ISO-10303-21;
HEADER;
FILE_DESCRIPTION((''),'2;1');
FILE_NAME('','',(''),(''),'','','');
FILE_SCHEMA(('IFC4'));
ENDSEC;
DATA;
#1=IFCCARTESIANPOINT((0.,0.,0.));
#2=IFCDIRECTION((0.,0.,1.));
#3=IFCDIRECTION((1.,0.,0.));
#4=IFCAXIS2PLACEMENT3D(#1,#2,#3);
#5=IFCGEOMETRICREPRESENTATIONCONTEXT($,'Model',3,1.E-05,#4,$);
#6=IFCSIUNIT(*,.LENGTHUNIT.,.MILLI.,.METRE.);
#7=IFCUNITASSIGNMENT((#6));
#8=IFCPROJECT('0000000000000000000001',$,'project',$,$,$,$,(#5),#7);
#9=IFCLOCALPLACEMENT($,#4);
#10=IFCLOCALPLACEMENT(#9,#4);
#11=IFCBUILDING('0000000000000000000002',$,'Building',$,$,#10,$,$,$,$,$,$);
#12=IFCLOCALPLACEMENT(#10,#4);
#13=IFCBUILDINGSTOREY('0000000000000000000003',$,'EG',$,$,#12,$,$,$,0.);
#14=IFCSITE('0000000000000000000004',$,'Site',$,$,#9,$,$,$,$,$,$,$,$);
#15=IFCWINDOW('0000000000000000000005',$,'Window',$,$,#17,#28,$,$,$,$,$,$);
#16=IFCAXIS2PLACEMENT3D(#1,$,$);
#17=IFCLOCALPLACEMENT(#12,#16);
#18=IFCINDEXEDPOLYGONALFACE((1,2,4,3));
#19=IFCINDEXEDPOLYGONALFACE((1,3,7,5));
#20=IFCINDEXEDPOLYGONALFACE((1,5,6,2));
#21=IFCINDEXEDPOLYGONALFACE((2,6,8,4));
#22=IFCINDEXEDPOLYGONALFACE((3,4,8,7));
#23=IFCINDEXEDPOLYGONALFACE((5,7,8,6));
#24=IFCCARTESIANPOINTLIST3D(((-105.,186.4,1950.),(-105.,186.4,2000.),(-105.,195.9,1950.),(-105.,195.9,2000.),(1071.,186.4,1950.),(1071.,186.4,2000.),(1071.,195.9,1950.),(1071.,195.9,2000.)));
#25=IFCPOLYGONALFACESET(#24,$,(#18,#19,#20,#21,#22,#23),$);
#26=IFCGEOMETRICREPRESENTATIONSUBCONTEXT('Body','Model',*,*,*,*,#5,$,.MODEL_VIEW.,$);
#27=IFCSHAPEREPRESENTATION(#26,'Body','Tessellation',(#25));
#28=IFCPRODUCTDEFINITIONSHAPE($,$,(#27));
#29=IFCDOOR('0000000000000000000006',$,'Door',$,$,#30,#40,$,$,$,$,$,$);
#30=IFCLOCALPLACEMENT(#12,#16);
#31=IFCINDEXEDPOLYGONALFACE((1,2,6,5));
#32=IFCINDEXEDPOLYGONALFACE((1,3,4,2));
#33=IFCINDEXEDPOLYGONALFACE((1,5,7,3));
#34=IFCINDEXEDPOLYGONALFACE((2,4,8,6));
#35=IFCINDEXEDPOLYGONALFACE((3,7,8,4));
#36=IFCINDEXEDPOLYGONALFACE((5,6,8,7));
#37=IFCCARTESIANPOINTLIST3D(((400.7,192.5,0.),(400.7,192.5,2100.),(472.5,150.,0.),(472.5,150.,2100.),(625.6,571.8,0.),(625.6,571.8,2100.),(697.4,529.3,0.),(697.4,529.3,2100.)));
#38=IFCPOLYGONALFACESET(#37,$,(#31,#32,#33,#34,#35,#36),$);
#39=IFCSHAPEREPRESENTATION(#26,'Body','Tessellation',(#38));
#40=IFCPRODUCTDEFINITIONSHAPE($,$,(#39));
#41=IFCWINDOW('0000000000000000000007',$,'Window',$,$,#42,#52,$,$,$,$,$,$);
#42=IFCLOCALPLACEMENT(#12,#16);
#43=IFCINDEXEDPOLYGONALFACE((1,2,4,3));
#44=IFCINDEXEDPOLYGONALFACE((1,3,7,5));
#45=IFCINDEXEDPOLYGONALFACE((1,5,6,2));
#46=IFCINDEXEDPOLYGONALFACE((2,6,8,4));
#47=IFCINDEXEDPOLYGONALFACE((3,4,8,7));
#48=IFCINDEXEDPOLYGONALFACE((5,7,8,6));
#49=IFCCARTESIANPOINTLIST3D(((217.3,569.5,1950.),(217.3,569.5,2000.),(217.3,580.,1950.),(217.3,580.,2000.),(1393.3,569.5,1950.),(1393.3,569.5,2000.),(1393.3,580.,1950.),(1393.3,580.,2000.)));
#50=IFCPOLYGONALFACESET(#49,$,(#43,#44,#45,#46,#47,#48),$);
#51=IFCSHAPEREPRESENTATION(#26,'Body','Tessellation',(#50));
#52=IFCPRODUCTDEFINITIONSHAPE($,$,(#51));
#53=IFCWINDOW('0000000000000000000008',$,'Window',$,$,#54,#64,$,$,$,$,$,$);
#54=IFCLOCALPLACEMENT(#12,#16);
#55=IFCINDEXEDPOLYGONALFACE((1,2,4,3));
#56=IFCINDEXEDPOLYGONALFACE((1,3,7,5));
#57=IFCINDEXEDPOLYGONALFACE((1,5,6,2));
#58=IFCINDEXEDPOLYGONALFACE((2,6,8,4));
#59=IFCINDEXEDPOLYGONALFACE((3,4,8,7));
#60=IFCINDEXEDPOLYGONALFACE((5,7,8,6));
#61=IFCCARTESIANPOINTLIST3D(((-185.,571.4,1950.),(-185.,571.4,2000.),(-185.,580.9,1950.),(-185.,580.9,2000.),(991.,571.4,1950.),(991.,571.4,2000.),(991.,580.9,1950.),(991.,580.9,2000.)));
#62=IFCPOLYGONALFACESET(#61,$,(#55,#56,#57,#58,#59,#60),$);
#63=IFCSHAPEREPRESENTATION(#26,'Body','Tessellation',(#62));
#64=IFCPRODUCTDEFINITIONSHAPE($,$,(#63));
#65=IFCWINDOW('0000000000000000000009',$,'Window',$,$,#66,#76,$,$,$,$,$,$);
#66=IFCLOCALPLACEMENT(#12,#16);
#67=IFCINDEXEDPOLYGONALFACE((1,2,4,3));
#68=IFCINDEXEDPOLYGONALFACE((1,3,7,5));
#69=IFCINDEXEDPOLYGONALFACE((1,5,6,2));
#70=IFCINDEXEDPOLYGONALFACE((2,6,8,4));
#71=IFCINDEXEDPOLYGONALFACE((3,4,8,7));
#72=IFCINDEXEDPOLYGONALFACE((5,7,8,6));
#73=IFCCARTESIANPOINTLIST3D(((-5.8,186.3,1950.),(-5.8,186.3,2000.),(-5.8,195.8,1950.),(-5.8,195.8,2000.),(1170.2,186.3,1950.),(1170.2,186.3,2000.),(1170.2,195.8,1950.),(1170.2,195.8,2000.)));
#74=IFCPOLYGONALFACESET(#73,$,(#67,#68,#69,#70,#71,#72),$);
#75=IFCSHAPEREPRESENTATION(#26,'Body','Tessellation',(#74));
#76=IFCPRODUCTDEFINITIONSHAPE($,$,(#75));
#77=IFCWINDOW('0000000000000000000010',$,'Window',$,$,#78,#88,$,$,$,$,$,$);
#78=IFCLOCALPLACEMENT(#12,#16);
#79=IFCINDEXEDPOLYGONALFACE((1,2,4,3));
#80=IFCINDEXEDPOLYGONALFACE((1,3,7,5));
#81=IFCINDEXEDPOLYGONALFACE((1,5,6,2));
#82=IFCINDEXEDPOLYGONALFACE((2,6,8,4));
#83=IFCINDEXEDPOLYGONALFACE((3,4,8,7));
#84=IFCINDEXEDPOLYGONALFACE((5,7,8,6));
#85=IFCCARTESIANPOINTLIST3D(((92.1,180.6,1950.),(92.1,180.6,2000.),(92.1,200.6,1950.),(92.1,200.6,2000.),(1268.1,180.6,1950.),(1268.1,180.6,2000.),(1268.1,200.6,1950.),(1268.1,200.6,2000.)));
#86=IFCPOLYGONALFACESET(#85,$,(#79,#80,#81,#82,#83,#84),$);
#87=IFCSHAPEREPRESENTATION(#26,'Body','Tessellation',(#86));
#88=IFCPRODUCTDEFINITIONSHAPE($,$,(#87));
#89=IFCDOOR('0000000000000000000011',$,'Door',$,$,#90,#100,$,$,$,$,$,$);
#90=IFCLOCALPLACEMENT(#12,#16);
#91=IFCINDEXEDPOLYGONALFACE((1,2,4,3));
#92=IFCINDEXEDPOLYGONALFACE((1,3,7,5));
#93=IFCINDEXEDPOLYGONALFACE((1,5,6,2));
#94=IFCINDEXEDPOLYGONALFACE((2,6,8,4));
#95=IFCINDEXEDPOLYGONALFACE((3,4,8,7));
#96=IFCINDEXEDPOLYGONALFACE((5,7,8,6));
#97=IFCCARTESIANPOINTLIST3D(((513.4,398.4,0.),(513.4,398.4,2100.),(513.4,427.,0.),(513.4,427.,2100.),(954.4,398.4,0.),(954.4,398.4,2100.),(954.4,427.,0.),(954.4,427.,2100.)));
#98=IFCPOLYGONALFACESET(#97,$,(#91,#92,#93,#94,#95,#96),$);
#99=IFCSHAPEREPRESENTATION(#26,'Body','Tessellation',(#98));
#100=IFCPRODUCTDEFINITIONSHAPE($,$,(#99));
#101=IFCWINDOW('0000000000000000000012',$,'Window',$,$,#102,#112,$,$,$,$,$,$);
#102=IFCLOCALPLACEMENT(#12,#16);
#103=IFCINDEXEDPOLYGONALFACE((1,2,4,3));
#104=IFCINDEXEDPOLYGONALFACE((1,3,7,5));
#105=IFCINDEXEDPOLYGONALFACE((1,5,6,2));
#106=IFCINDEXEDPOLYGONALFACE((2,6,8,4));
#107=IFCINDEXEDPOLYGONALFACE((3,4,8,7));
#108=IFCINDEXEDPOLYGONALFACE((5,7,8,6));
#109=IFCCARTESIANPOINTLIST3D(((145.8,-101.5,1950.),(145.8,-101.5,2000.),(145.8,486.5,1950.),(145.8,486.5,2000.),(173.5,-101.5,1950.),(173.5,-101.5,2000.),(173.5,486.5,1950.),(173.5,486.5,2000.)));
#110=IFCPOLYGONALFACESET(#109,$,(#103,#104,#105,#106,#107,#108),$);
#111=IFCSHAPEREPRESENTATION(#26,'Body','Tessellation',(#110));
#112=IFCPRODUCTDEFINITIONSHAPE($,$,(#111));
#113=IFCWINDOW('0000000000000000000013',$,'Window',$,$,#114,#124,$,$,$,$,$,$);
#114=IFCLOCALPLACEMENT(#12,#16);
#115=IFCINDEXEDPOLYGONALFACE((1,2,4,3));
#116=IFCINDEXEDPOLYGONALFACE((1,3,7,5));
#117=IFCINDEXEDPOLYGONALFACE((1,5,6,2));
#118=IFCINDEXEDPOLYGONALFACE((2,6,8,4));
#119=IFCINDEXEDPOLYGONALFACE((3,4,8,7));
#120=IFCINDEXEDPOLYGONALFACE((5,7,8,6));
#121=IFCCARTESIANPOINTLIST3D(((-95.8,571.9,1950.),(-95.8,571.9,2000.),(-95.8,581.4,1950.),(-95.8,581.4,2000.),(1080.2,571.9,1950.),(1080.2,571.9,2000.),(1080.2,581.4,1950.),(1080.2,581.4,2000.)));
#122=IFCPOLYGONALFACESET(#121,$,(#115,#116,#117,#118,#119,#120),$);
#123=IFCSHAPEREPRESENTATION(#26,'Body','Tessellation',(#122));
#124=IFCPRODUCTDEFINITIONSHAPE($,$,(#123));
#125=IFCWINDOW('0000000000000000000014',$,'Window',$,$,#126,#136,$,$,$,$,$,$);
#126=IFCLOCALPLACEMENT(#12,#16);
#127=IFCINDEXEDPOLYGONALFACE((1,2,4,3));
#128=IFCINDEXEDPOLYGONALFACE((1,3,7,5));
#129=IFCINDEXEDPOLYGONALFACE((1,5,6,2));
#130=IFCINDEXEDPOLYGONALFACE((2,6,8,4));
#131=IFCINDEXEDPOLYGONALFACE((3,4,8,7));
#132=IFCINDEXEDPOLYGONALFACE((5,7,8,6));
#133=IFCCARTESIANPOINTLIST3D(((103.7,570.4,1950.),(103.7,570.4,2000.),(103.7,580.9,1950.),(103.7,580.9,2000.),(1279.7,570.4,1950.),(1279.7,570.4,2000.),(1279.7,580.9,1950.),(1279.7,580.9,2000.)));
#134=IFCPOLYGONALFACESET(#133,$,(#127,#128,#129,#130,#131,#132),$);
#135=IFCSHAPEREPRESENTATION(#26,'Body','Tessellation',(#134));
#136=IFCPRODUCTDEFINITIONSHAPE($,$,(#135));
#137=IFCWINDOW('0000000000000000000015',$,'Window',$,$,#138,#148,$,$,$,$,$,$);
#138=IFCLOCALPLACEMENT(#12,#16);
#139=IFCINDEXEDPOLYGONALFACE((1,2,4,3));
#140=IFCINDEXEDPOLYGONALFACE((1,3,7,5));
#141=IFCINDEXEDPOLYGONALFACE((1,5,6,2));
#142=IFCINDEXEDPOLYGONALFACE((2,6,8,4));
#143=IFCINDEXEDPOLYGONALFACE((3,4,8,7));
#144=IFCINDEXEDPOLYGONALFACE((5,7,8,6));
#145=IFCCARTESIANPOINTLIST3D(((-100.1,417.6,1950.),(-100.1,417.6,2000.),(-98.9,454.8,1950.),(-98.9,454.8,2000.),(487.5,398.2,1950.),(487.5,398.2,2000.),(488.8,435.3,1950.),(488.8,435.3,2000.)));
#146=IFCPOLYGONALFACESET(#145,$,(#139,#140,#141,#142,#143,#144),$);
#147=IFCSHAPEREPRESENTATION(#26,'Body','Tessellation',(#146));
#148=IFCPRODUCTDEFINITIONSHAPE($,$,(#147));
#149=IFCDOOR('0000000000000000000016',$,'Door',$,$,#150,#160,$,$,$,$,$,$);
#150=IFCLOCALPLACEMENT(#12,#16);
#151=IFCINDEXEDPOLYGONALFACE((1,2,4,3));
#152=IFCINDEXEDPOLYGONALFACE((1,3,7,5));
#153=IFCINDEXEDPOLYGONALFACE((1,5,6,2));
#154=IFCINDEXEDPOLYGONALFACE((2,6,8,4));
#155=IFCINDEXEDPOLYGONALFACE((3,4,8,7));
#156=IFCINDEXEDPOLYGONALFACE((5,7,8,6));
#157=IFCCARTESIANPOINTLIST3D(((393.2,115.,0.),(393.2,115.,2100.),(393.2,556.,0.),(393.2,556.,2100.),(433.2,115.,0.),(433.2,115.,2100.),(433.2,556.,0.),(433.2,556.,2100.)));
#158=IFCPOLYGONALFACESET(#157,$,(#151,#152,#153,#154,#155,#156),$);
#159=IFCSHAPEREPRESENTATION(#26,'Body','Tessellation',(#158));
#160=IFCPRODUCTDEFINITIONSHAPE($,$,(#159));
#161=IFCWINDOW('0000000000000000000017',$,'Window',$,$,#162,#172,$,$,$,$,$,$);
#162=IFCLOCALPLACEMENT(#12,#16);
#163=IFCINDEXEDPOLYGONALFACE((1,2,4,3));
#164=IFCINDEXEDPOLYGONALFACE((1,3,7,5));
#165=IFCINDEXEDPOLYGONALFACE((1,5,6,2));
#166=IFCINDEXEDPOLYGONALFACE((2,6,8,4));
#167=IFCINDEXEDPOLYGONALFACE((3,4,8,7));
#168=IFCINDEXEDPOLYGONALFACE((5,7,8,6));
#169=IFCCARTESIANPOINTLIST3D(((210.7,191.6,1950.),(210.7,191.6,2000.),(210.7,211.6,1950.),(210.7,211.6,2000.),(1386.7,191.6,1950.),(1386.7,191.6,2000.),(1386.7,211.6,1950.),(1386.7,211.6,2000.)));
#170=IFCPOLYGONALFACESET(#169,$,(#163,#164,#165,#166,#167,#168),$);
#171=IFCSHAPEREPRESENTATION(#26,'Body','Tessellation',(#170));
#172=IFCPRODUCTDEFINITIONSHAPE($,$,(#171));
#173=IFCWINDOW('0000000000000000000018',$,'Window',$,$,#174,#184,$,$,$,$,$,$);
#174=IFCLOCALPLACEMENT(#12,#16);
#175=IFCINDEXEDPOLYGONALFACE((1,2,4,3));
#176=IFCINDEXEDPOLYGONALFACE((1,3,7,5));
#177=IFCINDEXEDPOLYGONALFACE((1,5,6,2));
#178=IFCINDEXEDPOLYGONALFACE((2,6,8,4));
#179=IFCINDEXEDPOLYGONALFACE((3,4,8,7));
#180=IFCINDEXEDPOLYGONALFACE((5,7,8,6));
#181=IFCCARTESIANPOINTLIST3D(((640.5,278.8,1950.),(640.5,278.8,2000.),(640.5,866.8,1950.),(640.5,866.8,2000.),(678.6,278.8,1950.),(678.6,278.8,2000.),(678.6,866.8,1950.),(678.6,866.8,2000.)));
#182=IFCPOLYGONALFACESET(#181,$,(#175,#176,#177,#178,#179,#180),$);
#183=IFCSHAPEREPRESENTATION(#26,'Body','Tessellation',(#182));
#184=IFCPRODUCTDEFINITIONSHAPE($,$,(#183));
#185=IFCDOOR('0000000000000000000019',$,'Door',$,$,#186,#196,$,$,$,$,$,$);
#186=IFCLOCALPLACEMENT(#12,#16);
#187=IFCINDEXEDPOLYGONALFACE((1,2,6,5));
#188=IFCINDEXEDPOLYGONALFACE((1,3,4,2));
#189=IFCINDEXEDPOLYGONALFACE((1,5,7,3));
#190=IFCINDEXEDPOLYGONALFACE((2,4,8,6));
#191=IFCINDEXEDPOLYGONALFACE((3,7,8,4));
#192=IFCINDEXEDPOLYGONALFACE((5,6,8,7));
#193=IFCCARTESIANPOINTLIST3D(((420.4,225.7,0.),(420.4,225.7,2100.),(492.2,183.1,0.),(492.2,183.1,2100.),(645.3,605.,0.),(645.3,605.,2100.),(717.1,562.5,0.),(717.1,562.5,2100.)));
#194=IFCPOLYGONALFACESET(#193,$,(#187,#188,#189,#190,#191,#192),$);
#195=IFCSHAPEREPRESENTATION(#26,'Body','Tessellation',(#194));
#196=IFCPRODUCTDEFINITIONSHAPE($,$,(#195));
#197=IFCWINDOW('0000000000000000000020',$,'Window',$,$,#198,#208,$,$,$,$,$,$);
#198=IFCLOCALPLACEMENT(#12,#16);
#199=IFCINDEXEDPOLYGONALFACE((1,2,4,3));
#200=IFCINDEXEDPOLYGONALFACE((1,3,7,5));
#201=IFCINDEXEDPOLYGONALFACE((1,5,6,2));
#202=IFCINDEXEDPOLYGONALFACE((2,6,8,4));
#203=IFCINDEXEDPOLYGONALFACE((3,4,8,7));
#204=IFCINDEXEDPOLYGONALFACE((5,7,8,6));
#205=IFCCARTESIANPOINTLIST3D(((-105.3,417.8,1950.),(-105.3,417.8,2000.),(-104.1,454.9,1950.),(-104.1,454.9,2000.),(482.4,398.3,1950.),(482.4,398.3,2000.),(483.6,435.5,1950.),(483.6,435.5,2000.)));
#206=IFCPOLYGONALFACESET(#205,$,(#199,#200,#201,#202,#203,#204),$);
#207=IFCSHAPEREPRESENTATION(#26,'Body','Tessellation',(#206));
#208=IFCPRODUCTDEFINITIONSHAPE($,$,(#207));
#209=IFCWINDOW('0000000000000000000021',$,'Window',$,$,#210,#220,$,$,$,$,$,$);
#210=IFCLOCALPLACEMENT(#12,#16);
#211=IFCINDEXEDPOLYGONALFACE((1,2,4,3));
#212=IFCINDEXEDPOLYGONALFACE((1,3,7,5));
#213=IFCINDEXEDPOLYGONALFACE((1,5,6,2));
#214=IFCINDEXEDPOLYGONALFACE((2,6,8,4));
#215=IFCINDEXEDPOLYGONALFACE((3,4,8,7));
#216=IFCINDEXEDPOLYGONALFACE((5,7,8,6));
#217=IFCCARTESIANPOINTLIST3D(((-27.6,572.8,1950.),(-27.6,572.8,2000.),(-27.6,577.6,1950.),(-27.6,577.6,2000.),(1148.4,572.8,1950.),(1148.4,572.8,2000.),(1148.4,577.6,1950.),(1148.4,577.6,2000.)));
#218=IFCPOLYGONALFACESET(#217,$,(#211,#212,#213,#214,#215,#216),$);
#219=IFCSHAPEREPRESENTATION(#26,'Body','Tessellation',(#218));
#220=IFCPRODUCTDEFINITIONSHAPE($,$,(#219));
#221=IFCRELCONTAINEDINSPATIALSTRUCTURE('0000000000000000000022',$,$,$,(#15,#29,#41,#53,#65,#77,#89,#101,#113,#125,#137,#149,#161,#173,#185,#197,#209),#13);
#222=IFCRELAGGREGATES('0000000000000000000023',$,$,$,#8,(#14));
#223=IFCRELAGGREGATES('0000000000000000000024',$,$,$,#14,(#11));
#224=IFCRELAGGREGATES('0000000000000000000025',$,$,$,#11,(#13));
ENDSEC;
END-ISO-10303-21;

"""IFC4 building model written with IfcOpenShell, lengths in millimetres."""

from ifc_helpers import new_model, si_unit, frame, origin_with_axes, place, context, subcontext, project, spatial, rectangle, extrude, element, save


model = new_model("IFC4")

# Units and contexts
model_context = context("Model", 3, precision=1e-05, world=origin_with_axes())
body_context = subcontext(model_context, "Body", "Model", "MODEL_VIEW")
ifc_project = project(units=[si_unit("LENGTHUNIT", "METRE", prefix="MILLI")], contexts=[model_context])

# Site, building, storey
site_placement = place(None, origin_with_axes())
site = spatial("IfcSite", under=ifc_project, at=site_placement, Name="Site")
building_placement = place(site_placement, origin_with_axes())
building = spatial("IfcBuilding", under=site, at=building_placement, Name="Building")
storey_placement = place(building_placement, origin_with_axes())
storey = spatial("IfcBuildingStorey", under=building, at=storey_placement, Name="EG", Elevation=0.0)

# Window
window_1_placement = place(storey_placement, origin_with_axes())
element("IfcWindow", 1, at=window_1_placement, inside=storey, Name="Window", context=body_context, shape_type="SweptSolid", body=[
    extrude(rectangle(XDim=1176.0, YDim=9.5), frame((483.0, 191.1, 1950.0), z_axis=(0.0, 0.0, 1.0), x_axis=(1.0, 0.0, 0.0)), (0.0, 0.0, 1.0), 50.0),
])

# Door
door_1_placement = place(storey_placement, origin_with_axes())
element("IfcDoor", 2, at=door_1_placement, inside=storey, Name="Door", context=body_context, shape_type="SweptSolid", body=[
    extrude(rectangle(XDim=441.0, YDim=83.5), frame((549.1, 360.9, 0.0), z_axis=(0.0, 0.0, 1.0), x_axis=(0.510011, 0.860168, 0.0)), (0.0, 0.0, 1.0), 2100.0),
])

# Windows
window_2_placement = place(storey_placement, origin_with_axes())
element("IfcWindow", 3, at=window_2_placement, inside=storey, Name="Window", context=body_context, shape_type="SweptSolid", body=[
    extrude(rectangle(XDim=1176.0, YDim=10.5), frame((805.3, 574.7, 1950.0), z_axis=(0.0, 0.0, 1.0), x_axis=(1.0, 0.0, 0.0)), (0.0, 0.0, 1.0), 50.0),
])
window_3_placement = place(storey_placement, origin_with_axes())
element("IfcWindow", 4, at=window_3_placement, inside=storey, Name="Window", context=body_context, shape_type="SweptSolid", body=[
    extrude(rectangle(XDim=1176.0, YDim=9.5), frame((403.0, 576.1, 1950.0), z_axis=(0.0, 0.0, 1.0), x_axis=(1.0, 0.0, 0.0)), (0.0, 0.0, 1.0), 50.0),
])
window_4_placement = place(storey_placement, origin_with_axes())
element("IfcWindow", 5, at=window_4_placement, inside=storey, Name="Window", context=body_context, shape_type="SweptSolid", body=[
    extrude(rectangle(XDim=1176.0, YDim=9.5), frame((582.2, 191.1, 1950.0), z_axis=(0.0, 0.0, 1.0), x_axis=(1.0, 0.0, 0.0)), (0.0, 0.0, 1.0), 50.0),
])
window_5_placement = place(storey_placement, origin_with_axes())
element("IfcWindow", 6, at=window_5_placement, inside=storey, Name="Window", context=body_context, shape_type="SweptSolid", body=[
    extrude(rectangle(XDim=1176.0, YDim=20.0), frame((680.1, 190.6, 1950.0), z_axis=(0.0, 0.0, 1.0), x_axis=(1.0, 0.0, 0.0)), (0.0, 0.0, 1.0), 50.0),
])

# Door
door_2_placement = place(storey_placement, origin_with_axes())
element("IfcDoor", 7, at=door_2_placement, inside=storey, Name="Door", context=body_context, shape_type="SweptSolid", body=[
    extrude(rectangle(XDim=441.0, YDim=28.6), frame((733.9, 412.7, 0.0), z_axis=(0.0, 0.0, 1.0), x_axis=(1.0, 0.0, 0.0)), (0.0, 0.0, 1.0), 2100.0),
])

# Windows
window_6_placement = place(storey_placement, origin_with_axes())
element("IfcWindow", 8, at=window_6_placement, inside=storey, Name="Window", context=body_context, shape_type="SweptSolid", body=[
    extrude(rectangle(XDim=588.0, YDim=27.6), frame((159.6, 192.5, 1950.0), z_axis=(0.0, 0.0, 1.0), x_axis=(0.0, -1.0, 0.0)), (0.0, 0.0, 1.0), 50.0),
])
window_7_placement = place(storey_placement, origin_with_axes())
element("IfcWindow", 9, at=window_7_placement, inside=storey, Name="Window", context=body_context, shape_type="SweptSolid", body=[
    extrude(rectangle(XDim=1176.0, YDim=9.5), frame((492.2, 576.6, 1950.0), z_axis=(0.0, 0.0, 1.0), x_axis=(1.0, 0.0, 0.0)), (0.0, 0.0, 1.0), 50.0),
])
window_8_placement = place(storey_placement, origin_with_axes())
element("IfcWindow", 10, at=window_8_placement, inside=storey, Name="Window", context=body_context, shape_type="SweptSolid", body=[
    extrude(rectangle(XDim=1176.0, YDim=10.5), frame((691.7, 575.6, 1950.0), z_axis=(0.0, 0.0, 1.0), x_axis=(1.0, 0.0, 0.0)), (0.0, 0.0, 1.0), 50.0),
])
window_9_placement = place(storey_placement, origin_with_axes())
element("IfcWindow", 11, at=window_9_placement, inside=storey, Name="Window", context=body_context, shape_type="SweptSolid", body=[
    extrude(rectangle(XDim=588.0, YDim=37.2), frame((194.3, 426.5, 1950.0), z_axis=(0.0, 0.0, 1.0), x_axis=(-0.999454, 0.03304, 0.0)), (0.0, 0.0, 1.0), 50.0),
])

# Door
door_3_placement = place(storey_placement, origin_with_axes())
element("IfcDoor", 12, at=door_3_placement, inside=storey, Name="Door", context=body_context, shape_type="SweptSolid", body=[
    extrude(rectangle(XDim=441.0, YDim=40.0), frame((413.2, 335.5, 0.0), z_axis=(0.0, 0.0, 1.0), x_axis=(0.0, 1.0, 0.0)), (0.0, 0.0, 1.0), 2100.0),
])

# Windows
window_10_placement = place(storey_placement, origin_with_axes())
element("IfcWindow", 13, at=window_10_placement, inside=storey, Name="Window", context=body_context, shape_type="SweptSolid", body=[
    extrude(rectangle(XDim=1176.0, YDim=20.0), frame((798.7, 201.6, 1950.0), z_axis=(0.0, 0.0, 1.0), x_axis=(1.0, 0.0, 0.0)), (0.0, 0.0, 1.0), 50.0),
])
window_11_placement = place(storey_placement, origin_with_axes())
element("IfcWindow", 14, at=window_11_placement, inside=storey, Name="Window", context=body_context, shape_type="SweptSolid", body=[
    extrude(rectangle(XDim=588.0, YDim=38.1), frame((659.6, 572.8, 1950.0), z_axis=(0.0, 0.0, 1.0), x_axis=(0.0, 1.0, 0.0)), (0.0, 0.0, 1.0), 50.0),
])

# Door
door_4_placement = place(storey_placement, origin_with_axes())
element("IfcDoor", 15, at=door_4_placement, inside=storey, Name="Door", context=body_context, shape_type="SweptSolid", body=[
    extrude(rectangle(XDim=441.0, YDim=83.5), frame((568.7, 394.1, 0.0), z_axis=(0.0, 0.0, 1.0), x_axis=(0.510011, 0.860168, 0.0)), (0.0, 0.0, 1.0), 2100.0),
])

# Windows
window_12_placement = place(storey_placement, origin_with_axes())
element("IfcWindow", 16, at=window_12_placement, inside=storey, Name="Window", context=body_context, shape_type="SweptSolid", body=[
    extrude(rectangle(XDim=588.0, YDim=37.2), frame((189.2, 426.6, 1950.0), z_axis=(0.0, 0.0, 1.0), x_axis=(-0.999454, 0.03304, 0.0)), (0.0, 0.0, 1.0), 50.0),
])
window_13_placement = place(storey_placement, origin_with_axes())
element("IfcWindow", 17, at=window_13_placement, inside=storey, Name="Window", context=body_context, shape_type="SweptSolid", body=[
    extrude(rectangle(XDim=1176.0, YDim=4.8), frame((560.4, 575.2, 1950.0), z_axis=(0.0, 0.0, 1.0), x_axis=(1.0, 0.0, 0.0)), (0.0, 0.0, 1.0), 50.0),
])

save(model, "model.ifc")
